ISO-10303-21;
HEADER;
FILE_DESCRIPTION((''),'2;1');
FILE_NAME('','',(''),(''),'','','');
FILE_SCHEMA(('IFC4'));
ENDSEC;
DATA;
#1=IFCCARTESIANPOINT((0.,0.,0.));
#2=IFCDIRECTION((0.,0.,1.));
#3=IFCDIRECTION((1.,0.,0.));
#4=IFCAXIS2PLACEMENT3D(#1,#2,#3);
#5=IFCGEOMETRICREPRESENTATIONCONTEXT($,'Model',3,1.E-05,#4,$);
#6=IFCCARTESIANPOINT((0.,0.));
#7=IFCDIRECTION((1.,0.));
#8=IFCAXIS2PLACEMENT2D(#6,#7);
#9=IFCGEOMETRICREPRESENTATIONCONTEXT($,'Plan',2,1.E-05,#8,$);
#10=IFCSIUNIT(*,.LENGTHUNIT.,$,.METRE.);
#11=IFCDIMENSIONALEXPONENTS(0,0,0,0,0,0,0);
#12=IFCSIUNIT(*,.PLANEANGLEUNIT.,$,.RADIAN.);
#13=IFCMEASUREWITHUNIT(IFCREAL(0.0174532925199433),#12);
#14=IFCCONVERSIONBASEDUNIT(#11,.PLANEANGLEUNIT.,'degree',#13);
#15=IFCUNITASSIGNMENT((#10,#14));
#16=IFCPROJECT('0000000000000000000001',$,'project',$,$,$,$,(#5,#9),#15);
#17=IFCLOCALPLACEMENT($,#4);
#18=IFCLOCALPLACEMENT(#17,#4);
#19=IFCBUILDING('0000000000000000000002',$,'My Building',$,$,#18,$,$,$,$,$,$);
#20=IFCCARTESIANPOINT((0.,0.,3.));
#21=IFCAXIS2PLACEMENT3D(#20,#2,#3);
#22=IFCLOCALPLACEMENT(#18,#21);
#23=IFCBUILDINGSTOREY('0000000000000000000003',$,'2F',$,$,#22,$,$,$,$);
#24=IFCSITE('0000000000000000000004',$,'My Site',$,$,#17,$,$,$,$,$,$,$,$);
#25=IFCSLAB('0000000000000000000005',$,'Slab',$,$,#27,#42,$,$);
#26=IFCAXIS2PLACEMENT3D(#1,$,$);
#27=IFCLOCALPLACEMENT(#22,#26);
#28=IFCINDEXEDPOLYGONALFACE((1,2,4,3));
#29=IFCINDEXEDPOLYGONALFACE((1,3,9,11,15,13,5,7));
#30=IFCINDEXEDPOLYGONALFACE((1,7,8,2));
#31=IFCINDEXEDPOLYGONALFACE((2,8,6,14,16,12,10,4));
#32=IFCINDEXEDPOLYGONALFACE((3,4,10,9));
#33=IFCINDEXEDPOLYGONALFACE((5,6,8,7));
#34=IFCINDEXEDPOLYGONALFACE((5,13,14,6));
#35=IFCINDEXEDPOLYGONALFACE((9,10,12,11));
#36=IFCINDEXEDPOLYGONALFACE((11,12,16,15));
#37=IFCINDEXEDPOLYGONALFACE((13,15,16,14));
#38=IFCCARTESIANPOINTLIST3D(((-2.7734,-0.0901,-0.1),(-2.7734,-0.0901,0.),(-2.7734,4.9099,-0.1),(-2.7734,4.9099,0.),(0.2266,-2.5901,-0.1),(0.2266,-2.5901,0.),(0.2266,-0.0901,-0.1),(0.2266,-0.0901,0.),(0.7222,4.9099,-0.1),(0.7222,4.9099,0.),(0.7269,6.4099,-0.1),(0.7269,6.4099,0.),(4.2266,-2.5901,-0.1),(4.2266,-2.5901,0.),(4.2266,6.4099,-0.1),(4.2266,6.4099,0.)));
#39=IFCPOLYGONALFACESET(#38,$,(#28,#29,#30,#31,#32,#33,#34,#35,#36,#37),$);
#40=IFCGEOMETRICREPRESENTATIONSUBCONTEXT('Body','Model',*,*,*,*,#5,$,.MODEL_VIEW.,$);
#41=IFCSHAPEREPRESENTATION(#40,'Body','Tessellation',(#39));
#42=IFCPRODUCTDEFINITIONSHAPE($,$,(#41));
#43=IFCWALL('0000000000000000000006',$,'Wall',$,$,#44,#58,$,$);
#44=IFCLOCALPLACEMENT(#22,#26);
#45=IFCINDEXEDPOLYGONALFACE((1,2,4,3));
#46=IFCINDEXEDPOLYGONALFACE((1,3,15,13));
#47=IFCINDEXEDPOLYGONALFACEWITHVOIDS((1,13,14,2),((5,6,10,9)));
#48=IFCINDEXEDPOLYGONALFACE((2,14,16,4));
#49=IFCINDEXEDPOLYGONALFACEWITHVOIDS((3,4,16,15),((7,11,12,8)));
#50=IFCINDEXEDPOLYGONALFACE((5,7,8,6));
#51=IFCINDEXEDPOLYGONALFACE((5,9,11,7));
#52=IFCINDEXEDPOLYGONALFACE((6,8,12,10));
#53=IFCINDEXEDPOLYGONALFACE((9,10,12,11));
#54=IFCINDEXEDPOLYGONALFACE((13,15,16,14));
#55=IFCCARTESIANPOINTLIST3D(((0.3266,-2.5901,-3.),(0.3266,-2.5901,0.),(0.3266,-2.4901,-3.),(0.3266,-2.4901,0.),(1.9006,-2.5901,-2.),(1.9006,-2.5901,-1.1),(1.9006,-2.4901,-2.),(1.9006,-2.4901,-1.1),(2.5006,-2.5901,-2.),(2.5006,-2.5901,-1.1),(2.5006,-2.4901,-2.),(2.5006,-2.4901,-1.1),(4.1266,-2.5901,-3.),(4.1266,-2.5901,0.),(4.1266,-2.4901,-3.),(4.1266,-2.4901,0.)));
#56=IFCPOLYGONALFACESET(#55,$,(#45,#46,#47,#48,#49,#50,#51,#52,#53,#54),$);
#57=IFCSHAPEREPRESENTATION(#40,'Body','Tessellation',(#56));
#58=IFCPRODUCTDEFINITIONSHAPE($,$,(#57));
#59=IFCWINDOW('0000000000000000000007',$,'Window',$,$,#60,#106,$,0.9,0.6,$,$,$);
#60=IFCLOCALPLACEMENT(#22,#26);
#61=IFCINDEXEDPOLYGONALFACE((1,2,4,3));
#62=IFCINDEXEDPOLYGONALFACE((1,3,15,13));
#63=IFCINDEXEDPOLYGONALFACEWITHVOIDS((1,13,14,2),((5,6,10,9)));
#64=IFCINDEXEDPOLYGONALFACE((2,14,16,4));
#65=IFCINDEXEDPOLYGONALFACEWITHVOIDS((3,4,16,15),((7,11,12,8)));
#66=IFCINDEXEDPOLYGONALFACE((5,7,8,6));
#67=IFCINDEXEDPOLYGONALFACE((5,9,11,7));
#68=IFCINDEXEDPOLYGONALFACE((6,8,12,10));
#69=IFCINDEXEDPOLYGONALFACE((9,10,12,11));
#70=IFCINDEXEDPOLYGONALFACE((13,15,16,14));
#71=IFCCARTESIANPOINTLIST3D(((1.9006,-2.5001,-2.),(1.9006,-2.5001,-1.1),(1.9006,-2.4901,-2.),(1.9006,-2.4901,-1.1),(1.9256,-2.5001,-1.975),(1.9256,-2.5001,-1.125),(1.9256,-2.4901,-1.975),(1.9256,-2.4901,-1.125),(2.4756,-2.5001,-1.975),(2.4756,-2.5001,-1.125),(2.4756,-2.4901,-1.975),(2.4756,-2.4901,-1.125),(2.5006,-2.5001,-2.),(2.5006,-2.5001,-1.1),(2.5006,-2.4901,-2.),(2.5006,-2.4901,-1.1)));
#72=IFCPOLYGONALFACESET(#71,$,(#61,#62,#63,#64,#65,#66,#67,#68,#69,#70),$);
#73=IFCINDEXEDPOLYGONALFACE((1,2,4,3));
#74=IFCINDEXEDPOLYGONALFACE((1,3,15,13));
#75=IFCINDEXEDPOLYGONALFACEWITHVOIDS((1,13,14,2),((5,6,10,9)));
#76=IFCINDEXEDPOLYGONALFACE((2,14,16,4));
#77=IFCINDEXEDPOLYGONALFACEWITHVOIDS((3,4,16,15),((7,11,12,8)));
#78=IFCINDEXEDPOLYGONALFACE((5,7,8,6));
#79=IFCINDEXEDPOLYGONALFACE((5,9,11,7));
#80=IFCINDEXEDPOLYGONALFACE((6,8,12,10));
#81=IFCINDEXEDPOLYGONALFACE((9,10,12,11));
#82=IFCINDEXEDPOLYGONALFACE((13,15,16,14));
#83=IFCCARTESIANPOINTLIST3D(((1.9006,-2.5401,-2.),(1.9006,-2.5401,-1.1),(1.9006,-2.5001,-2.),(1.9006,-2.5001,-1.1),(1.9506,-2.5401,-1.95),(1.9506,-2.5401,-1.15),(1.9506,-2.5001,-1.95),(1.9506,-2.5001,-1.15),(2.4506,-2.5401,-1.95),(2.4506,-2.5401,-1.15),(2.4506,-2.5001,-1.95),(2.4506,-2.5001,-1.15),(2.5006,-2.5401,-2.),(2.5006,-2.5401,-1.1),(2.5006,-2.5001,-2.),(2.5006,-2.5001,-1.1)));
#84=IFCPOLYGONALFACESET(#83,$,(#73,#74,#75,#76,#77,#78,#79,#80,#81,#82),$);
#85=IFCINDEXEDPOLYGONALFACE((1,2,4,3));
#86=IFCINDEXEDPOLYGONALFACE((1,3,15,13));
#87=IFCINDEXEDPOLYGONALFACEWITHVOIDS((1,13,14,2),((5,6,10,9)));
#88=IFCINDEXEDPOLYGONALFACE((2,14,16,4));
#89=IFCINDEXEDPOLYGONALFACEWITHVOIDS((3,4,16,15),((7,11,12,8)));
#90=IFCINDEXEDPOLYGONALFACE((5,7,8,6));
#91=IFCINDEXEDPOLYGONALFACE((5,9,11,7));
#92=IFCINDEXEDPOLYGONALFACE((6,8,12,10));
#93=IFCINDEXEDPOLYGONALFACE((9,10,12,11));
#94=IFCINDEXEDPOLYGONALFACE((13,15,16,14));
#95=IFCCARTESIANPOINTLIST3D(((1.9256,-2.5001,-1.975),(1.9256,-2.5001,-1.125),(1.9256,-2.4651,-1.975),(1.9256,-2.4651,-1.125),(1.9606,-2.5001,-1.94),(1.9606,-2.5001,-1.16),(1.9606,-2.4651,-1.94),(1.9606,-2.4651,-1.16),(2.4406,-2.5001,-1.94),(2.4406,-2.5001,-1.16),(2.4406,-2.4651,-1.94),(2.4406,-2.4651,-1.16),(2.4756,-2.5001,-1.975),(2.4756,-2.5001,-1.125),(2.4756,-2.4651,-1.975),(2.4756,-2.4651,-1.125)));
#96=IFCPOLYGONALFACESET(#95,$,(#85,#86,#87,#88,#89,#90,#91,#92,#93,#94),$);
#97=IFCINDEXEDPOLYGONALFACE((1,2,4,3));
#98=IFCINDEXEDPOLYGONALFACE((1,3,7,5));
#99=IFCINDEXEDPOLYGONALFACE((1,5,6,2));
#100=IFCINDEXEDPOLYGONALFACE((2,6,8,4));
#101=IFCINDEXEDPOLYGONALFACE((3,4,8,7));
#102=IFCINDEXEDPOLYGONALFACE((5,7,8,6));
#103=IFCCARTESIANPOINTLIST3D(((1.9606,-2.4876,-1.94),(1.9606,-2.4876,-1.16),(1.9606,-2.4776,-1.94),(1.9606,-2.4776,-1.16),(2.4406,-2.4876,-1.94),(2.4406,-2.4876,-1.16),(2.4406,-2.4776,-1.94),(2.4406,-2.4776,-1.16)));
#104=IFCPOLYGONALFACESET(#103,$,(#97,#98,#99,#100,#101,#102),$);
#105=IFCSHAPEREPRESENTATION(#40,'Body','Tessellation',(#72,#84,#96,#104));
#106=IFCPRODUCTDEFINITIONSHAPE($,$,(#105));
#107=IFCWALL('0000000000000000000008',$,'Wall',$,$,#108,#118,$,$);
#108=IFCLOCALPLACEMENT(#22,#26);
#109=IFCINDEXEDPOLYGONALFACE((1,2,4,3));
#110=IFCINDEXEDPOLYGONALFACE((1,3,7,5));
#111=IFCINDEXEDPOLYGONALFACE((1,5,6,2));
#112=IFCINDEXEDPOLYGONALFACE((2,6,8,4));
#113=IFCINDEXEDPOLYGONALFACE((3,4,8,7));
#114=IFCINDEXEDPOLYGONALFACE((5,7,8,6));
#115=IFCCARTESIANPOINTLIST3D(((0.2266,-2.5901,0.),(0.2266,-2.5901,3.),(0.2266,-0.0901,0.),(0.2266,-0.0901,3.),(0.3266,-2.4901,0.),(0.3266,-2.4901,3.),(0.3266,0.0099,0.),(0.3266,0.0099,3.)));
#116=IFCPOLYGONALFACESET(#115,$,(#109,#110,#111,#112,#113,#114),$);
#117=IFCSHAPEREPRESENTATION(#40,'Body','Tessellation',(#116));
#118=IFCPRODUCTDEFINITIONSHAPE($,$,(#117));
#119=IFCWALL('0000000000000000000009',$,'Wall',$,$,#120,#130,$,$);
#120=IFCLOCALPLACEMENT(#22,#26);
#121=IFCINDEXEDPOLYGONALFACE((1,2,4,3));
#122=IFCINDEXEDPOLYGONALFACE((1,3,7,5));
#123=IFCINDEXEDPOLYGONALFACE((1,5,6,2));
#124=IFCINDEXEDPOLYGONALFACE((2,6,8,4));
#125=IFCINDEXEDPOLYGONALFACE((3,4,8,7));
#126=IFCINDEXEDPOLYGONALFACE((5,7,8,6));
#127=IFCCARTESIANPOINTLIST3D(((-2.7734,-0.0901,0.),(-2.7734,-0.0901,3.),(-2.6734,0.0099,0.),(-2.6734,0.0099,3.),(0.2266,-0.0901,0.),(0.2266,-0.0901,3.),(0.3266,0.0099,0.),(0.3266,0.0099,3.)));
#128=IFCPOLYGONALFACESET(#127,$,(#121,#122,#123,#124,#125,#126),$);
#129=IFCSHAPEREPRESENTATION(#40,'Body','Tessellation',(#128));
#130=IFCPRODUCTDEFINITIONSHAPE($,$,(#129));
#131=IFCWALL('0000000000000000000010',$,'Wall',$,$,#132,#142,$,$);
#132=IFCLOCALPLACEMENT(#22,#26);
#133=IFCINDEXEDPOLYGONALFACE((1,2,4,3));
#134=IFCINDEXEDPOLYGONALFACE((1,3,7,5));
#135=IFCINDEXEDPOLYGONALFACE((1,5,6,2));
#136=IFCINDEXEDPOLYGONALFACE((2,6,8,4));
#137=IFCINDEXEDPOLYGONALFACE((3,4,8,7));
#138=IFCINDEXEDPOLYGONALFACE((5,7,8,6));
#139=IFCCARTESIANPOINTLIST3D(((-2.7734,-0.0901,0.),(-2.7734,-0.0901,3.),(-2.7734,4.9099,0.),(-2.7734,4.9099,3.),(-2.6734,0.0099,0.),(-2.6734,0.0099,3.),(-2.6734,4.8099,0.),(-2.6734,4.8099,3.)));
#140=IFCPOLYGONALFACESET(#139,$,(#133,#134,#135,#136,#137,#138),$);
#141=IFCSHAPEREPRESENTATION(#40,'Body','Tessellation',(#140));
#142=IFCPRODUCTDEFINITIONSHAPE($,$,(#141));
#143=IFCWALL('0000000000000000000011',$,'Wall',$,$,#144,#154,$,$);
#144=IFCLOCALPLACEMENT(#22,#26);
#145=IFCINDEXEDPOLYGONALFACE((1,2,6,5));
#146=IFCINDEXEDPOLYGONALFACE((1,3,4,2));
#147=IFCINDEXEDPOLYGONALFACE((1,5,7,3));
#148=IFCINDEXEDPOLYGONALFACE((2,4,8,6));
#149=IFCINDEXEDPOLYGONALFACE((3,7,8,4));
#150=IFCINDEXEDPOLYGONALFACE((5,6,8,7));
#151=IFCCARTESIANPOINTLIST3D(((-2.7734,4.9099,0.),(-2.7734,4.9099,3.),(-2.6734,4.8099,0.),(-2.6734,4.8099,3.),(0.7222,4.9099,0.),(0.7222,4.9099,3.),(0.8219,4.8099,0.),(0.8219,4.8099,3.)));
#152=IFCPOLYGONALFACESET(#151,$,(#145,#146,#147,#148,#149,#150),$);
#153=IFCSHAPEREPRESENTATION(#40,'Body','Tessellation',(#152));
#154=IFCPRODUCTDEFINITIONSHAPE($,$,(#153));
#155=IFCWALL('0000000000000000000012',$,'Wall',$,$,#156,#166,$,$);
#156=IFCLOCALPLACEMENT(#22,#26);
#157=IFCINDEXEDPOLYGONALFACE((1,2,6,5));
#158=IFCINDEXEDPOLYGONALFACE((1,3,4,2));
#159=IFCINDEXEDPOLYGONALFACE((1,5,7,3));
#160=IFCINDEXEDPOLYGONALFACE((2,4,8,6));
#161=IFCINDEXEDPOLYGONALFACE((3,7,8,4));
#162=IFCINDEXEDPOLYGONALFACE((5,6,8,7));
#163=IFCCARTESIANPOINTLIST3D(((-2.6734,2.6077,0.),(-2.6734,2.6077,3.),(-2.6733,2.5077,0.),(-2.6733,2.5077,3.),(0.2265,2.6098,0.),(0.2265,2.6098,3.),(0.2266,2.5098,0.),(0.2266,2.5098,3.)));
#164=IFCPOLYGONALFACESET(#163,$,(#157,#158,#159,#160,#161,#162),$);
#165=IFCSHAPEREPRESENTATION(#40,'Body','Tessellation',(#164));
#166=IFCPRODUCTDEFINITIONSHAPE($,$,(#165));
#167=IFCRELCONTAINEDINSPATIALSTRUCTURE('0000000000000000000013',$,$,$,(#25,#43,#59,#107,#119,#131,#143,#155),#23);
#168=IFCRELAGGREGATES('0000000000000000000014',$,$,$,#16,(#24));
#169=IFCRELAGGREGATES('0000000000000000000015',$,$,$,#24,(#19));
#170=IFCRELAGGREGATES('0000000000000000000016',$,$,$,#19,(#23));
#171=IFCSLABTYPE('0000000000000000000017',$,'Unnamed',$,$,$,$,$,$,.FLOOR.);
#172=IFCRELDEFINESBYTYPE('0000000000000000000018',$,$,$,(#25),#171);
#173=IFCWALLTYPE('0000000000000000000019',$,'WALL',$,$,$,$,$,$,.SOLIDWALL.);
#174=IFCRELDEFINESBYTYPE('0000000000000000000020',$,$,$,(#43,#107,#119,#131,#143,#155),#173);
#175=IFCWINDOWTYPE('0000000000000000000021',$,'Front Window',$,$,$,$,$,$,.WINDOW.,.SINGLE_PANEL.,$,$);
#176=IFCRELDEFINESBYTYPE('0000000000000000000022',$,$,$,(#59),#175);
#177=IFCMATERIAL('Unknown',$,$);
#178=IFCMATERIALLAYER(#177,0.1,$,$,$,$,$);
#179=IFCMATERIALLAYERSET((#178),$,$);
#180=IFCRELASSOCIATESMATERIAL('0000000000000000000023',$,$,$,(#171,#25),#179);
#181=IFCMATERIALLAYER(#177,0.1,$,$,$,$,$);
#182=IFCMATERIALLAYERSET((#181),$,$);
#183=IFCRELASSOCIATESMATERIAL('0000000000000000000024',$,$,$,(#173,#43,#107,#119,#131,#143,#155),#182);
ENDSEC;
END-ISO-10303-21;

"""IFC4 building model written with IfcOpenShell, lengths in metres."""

from ifc_helpers import new_model, entity, si_unit, converted_unit, frame, origin_with_axes, origin_2d_with_axis, place, context, subcontext, project, spatial, line, indexed_curve, outline, extrude, shape, source, transform, mapped, material, layer, layer_set, layer_usage, type_object, type_shapes, element, fill, save


model = new_model("IFC4")

# Units and contexts
model_context = context("Model", 3, precision=1e-05, world=origin_with_axes())
plan_context = context("Plan", 2, precision=1e-05, world=origin_2d_with_axis())
body_context_1 = subcontext(model_context, "Body", "Model", "MODEL_VIEW")
body_context_2 = subcontext(plan_context, "Body", "Plan", "PLAN_VIEW")
ifc_project = project(units=[si_unit("LENGTHUNIT", "METRE"), converted_unit("PLANEANGLEUNIT", "degree", entity("IfcReal", 0.0174532925199433), si_unit("PLANEANGLEUNIT", "RADIAN"), dimensions=[0, 0, 0, 0, 0, 0, 0])], contexts=[model_context, plan_context])

# Site, building, storey
site_placement = place(None, origin_with_axes())
site = spatial("IfcSite", under=ifc_project, at=site_placement, Name="My Site")
building_placement = place(site_placement, origin_with_axes())
building = spatial("IfcBuilding", under=site, at=building_placement, Name="My Building")
storey_placement = place(building_placement, frame((0.0, 0.0, 3.0), z_axis=(0.0, 0.0, 1.0), x_axis=(1.0, 0.0, 0.0)))
storey = spatial("IfcBuildingStorey", under=building, at=storey_placement, Name="2F")

# Slab
ifc_material = material(Name="Unknown")
ifc_layer_1 = layer(ifc_material, 0.1)
ifc_layer_set_1 = layer_set([ifc_layer_1])
ifc_layer_usage_1 = layer_usage(ifc_layer_set_1, "AXIS3", "POSITIVE", -0.1)
slab_type = type_object("IfcSlabType", Name="Unnamed", PredefinedType="FLOOR", material=ifc_layer_set_1)
slab_placement = place(storey_placement, frame((-2.7734, 4.9099, 0.0), z_axis=(0.0, 0.0, 1.0), x_axis=(1.0, 0.0, 0.0)))
element("IfcSlab", 1, at=slab_placement, inside=storey, type_object=slab_type, material=ifc_layer_usage_1, Name="Slab", context=body_context_1, shape_type="SweptSolid", body=[
    extrude(outline(indexed_curve([(0.0, 0.0), (3.4956, 0.0), (3.5003, 1.5), (7.0, 1.5), (7.0, -7.5), (3.0, -7.5), (3.0, -5.0), (0.0, -5.0), (0.0, 0.0)])), frame((0.0, 0.0, -0.1), z_axis=(0.0, 0.0, 1.0), x_axis=(1.0, 0.0, 0.0)), (0.0, 0.0, 1.0), 0.1),
])

# Wall, opening, window
ifc_layer_2 = layer(ifc_material, 0.1)
ifc_layer_set_2 = layer_set([ifc_layer_2])
ifc_layer_usage_2 = layer_usage(ifc_layer_set_2, "AXIS2", "POSITIVE", 0.0)
wall_type = type_object("IfcWallType", Name="WALL", PredefinedType="SOLIDWALL", material=ifc_layer_set_2)
wall_1_placement = place(storey_placement, frame((0.3266, -2.5901, -3.0), z_axis=(0.0, 0.0, 1.0), x_axis=(1.0, 0.0, 0.0)))
wall_1 = element("IfcWall", 2, at=wall_1_placement, inside=storey, type_object=wall_type, material=ifc_layer_usage_2, Name="Wall", context=body_context_1, shape_type="SweptSolid", body=[
    extrude(outline(indexed_curve([(0.0, 0.0), (0.0, 0.1), (3.8, 0.1), (3.8, 0.0)], segments=[line(1, 2, 3, 4, 1)])), origin_with_axes(), (0.0, 0.0, 1.0), 3.0),
])
shared_shape_1 = source(origin_with_axes(), body_context_1, "Body", "SweptSolid", [
    extrude(outline(indexed_curve([(0.0, 0.0), (0.6, 0.0), (0.6, 0.9), (0.0, 0.9)], segments=[line(1, 2, 3, 4, 1)])), frame((0.0, -0.6, 0.0), z_axis=(0.0, -1.0, 0.0), x_axis=(1.0, 0.0, 0.0)), (0.0, 0.0, -1.0), 1.2),
])
opening_1_placement = place(wall_1_placement, frame((1.574, 0.0, 1.0), z_axis=(0.0, 0.0, 1.0), x_axis=(1.0, 0.0, 0.0)))
opening_1 = element("IfcOpeningElement", 3, at=opening_1_placement, cuts=wall_1, PredefinedType="OPENING", context=body_context_1, shape_type="MappedRepresentation", body=[
    mapped(shared_shape_1, transform((0.0, 0.0, 0.0), x_axis=(1.0, 0.0, 0.0), y_axis=(0.0, 1.0, 0.0), z_axis=(0.0, 0.0, 1.0), scale=1.0)),
])
window_type_1 = type_object("IfcWindowType", Name="Front Window", PartitioningType="SINGLE_PANEL", PredefinedType="WINDOW")
shared_shape_2 = source(origin_with_axes(), body_context_1, "Body", "SweptSolid", [
    extrude(outline(indexed_curve([(0.0, 0.0), (0.6, 0.0), (0.6, 0.9), (0.0, 0.9)], segments=[line(1, 2, 3, 4, 1)]), holes=[indexed_curve([(0.025, 0.025), (0.575, 0.025), (0.575, 0.875), (0.025, 0.875)], segments=[line(1, 2, 3, 4, 1)])]), frame((0.0, 0.09, 0.0), z_axis=(0.0, -1.0, 0.0), x_axis=(1.0, 0.0, 0.0)), (0.0, 0.0, -1.0), 0.01),
    extrude(outline(indexed_curve([(0.0, 0.0), (0.6, 0.0), (0.6, 0.9), (0.0, 0.9)], segments=[line(1, 2, 3, 4, 1)]), holes=[indexed_curve([(0.05, 0.05), (0.55, 0.05), (0.55, 0.85), (0.05, 0.85)], segments=[line(1, 2, 3, 4, 1)])]), frame((0.0, 0.05, 0.0), z_axis=(0.0, -1.0, 0.0), x_axis=(1.0, 0.0, 0.0)), (0.0, 0.0, -1.0), 0.04),
    extrude(outline(indexed_curve([(0.0, 0.0), (0.55, 0.0), (0.55, 0.85), (0.0, 0.85)], segments=[line(1, 2, 3, 4, 1)]), holes=[indexed_curve([(0.035, 0.035), (0.515, 0.035), (0.515, 0.815), (0.035, 0.815)], segments=[line(1, 2, 3, 4, 1)])]), frame((0.025, 0.09, 0.025), z_axis=(0.0, -1.0, 0.0), x_axis=(1.0, 0.0, 0.0)), (0.0, 0.0, -1.0), 0.035),
    extrude(outline(indexed_curve([(0.035, 0.035), (0.515, 0.035), (0.515, 0.815), (0.035, 0.815)], segments=[line(1, 2, 3, 4, 1)])), frame((0.025, 0.1025, 0.025), z_axis=(0.0, -1.0, 0.0), x_axis=(1.0, 0.0, 0.0)), (0.0, 0.0, -1.0), 0.01),
])
shared_shape_3 = source(origin_with_axes(), body_context_2, "Body", "Curve2D", [
    entity("IfcIndexedPolyCurve", entity("IfcCartesianPointList2D", [[0.05, 0.05], [0.55, 0.05]])),
    entity("IfcIndexedPolyCurve", entity("IfcCartesianPointList2D", [[0.0, 0.1], [0.025, 0.1], [0.025, 0.09], [0.05, 0.09], [0.05, 0.05], [0.0, 0.05]]), [entity("IfcLineIndex", [1, 2, 3, 4, 5, 6, 1])]),
    entity("IfcIndexedPolyCurve", entity("IfcCartesianPointList2D", [[0.6, 0.1], [0.575, 0.1], [0.575, 0.09], [0.55, 0.09], [0.55, 0.05], [0.6, 0.05]]), [entity("IfcLineIndex", [1, 2, 3, 4, 5, 6, 1])]),
    entity("IfcIndexedPolyCurve", entity("IfcCartesianPointList2D", [[0.025, 0.09], [0.06, 0.09], [0.06, 0.125], [0.025, 0.125]]), [entity("IfcLineIndex", [1, 2, 3, 4, 1])]),
    entity("IfcIndexedPolyCurve", entity("IfcCartesianPointList2D", [[0.575, 0.09], [0.54, 0.09], [0.54, 0.125], [0.575, 0.125]]), [entity("IfcLineIndex", [1, 2, 3, 4, 1])]),
    entity("IfcIndexedPolyCurve", entity("IfcCartesianPointList2D", [[0.06, 0.09], [0.54, 0.09]])),
    entity("IfcIndexedPolyCurve", entity("IfcCartesianPointList2D", [[0.06, 0.125], [0.54, 0.125]])),
    entity("IfcIndexedPolyCurve", entity("IfcCartesianPointList2D", [[0.06, 0.1075], [0.54, 0.1075]])),
])
type_shapes(window_type_1, [shared_shape_2, shared_shape_3])
window_1_placement = place(opening_1_placement, origin_with_axes())
window_1 = element("IfcWindow", 4, at=window_1_placement, inside=storey, type_object=window_type_1, Name="Window", OverallHeight=0.9, OverallWidth=0.6, shapes=[
    shape(body_context_1, "Body", "MappedRepresentation", [mapped(shared_shape_2, transform((0.0, 0.0, 0.0), x_axis=(1.0, 0.0, 0.0), y_axis=(0.0, 1.0, 0.0), z_axis=(0.0, 0.0, 1.0), scale=1.0))]),
    shape(body_context_2, "Body", "MappedRepresentation", [mapped(shared_shape_3, transform((0.0, 0.0, 0.0), x_axis=(1.0, 0.0, 0.0), y_axis=(0.0, 1.0, 0.0), z_axis=(0.0, 0.0, 1.0), scale=1.0))]),
])
fill(opening_1, window_1)

# Walls
ifc_layer_usage_3 = layer_usage(ifc_layer_set_2, "AXIS2", "POSITIVE", 0.0)
wall_2_placement = place(storey_placement, frame((0.3266, -2.4901, 0.0), z_axis=(0.0, 0.0, 1.0), x_axis=(0.0, 1.0, 0.0)))
element("IfcWall", 5, at=wall_2_placement, inside=storey, type_object=wall_type, material=ifc_layer_usage_3, Name="Wall", context=body_context_1, shape_type="SweptSolid", body=[
    extrude(outline(indexed_curve([(0.0, 0.0), (-0.1, 0.1), (2.4, 0.1), (2.5, 0.0)], segments=[line(1, 2, 3, 4, 1)])), origin_with_axes(), (0.0, 0.0, 1.0), 3.0),
])
ifc_layer_usage_4 = layer_usage(ifc_layer_set_2, "AXIS2", "POSITIVE", 0.0)
wall_3_placement = place(storey_placement, frame((0.3266, 0.0099, 0.0), z_axis=(0.0, 0.0, 1.0), x_axis=(-1.0, 0.0, 0.0)))
element("IfcWall", 6, at=wall_3_placement, inside=storey, type_object=wall_type, material=ifc_layer_usage_4, Name="Wall", context=body_context_1, shape_type="SweptSolid", body=[
    extrude(outline(indexed_curve([(0.0, 0.0), (0.1, 0.1), (3.1, 0.1), (3.0, 0.0)], segments=[line(1, 2, 3, 4, 1)])), origin_with_axes(), (0.0, 0.0, 1.0), 3.0),
])
ifc_layer_usage_5 = layer_usage(ifc_layer_set_2, "AXIS2", "POSITIVE", 0.0)
wall_4_placement = place(storey_placement, frame((-2.6734, 0.0099, 0.0), z_axis=(0.0, 0.0, 1.0), x_axis=(0.0, 1.0, 0.0)))
element("IfcWall", 7, at=wall_4_placement, inside=storey, type_object=wall_type, material=ifc_layer_usage_5, Name="Wall", context=body_context_1, shape_type="SweptSolid", body=[
    extrude(outline(indexed_curve([(0.0, 0.0), (-0.1, 0.1), (4.9, 0.1), (4.8, 0.0)], segments=[line(1, 2, 3, 4, 1)])), origin_with_axes(), (0.0, 0.0, 1.0), 3.0),
])
ifc_layer_usage_6 = layer_usage(ifc_layer_set_2, "AXIS2", "POSITIVE", 0.0)
wall_5_placement = place(storey_placement, frame((-2.6734, 4.8099, 0.0), z_axis=(0.0, 0.0, 1.0), x_axis=(1.0, 0.0, 0.0)))
element("IfcWall", 8, at=wall_5_placement, inside=storey, type_object=wall_type, material=ifc_layer_usage_6, Name="Wall", context=body_context_1, shape_type="SweptSolid", body=[
    extrude(outline(indexed_curve([(0.0, 0.0), (-0.1, 0.1), (3.3956, 0.1), (3.4953, 0.0)], segments=[line(1, 2, 3, 4, 1)])), origin_with_axes(), (0.0, 0.0, 1.0), 3.0),
])
ifc_layer_usage_7 = layer_usage(ifc_layer_set_2, "AXIS2", "POSITIVE", 0.0)
wall_6_placement = place(storey_placement, frame((-2.6733, 2.5077, 0.0), z_axis=(0.0, 0.0, 1.0), x_axis=(1.0, 0.000723, 0.0)))
element("IfcWall", 9, at=wall_6_placement, inside=storey, type_object=wall_type, material=ifc_layer_usage_7, Name="Wall", context=body_context_1, shape_type="SweptSolid", body=[
    extrude(outline(indexed_curve([(0.0, 0.0), (0.0, 0.1), (2.8999, 0.1), (2.8999, 0.0)], segments=[line(1, 2, 3, 4, 1)])), origin_with_axes(), (0.0, 0.0, 1.0), 3.0),
])

save(model, "model.ifc")
